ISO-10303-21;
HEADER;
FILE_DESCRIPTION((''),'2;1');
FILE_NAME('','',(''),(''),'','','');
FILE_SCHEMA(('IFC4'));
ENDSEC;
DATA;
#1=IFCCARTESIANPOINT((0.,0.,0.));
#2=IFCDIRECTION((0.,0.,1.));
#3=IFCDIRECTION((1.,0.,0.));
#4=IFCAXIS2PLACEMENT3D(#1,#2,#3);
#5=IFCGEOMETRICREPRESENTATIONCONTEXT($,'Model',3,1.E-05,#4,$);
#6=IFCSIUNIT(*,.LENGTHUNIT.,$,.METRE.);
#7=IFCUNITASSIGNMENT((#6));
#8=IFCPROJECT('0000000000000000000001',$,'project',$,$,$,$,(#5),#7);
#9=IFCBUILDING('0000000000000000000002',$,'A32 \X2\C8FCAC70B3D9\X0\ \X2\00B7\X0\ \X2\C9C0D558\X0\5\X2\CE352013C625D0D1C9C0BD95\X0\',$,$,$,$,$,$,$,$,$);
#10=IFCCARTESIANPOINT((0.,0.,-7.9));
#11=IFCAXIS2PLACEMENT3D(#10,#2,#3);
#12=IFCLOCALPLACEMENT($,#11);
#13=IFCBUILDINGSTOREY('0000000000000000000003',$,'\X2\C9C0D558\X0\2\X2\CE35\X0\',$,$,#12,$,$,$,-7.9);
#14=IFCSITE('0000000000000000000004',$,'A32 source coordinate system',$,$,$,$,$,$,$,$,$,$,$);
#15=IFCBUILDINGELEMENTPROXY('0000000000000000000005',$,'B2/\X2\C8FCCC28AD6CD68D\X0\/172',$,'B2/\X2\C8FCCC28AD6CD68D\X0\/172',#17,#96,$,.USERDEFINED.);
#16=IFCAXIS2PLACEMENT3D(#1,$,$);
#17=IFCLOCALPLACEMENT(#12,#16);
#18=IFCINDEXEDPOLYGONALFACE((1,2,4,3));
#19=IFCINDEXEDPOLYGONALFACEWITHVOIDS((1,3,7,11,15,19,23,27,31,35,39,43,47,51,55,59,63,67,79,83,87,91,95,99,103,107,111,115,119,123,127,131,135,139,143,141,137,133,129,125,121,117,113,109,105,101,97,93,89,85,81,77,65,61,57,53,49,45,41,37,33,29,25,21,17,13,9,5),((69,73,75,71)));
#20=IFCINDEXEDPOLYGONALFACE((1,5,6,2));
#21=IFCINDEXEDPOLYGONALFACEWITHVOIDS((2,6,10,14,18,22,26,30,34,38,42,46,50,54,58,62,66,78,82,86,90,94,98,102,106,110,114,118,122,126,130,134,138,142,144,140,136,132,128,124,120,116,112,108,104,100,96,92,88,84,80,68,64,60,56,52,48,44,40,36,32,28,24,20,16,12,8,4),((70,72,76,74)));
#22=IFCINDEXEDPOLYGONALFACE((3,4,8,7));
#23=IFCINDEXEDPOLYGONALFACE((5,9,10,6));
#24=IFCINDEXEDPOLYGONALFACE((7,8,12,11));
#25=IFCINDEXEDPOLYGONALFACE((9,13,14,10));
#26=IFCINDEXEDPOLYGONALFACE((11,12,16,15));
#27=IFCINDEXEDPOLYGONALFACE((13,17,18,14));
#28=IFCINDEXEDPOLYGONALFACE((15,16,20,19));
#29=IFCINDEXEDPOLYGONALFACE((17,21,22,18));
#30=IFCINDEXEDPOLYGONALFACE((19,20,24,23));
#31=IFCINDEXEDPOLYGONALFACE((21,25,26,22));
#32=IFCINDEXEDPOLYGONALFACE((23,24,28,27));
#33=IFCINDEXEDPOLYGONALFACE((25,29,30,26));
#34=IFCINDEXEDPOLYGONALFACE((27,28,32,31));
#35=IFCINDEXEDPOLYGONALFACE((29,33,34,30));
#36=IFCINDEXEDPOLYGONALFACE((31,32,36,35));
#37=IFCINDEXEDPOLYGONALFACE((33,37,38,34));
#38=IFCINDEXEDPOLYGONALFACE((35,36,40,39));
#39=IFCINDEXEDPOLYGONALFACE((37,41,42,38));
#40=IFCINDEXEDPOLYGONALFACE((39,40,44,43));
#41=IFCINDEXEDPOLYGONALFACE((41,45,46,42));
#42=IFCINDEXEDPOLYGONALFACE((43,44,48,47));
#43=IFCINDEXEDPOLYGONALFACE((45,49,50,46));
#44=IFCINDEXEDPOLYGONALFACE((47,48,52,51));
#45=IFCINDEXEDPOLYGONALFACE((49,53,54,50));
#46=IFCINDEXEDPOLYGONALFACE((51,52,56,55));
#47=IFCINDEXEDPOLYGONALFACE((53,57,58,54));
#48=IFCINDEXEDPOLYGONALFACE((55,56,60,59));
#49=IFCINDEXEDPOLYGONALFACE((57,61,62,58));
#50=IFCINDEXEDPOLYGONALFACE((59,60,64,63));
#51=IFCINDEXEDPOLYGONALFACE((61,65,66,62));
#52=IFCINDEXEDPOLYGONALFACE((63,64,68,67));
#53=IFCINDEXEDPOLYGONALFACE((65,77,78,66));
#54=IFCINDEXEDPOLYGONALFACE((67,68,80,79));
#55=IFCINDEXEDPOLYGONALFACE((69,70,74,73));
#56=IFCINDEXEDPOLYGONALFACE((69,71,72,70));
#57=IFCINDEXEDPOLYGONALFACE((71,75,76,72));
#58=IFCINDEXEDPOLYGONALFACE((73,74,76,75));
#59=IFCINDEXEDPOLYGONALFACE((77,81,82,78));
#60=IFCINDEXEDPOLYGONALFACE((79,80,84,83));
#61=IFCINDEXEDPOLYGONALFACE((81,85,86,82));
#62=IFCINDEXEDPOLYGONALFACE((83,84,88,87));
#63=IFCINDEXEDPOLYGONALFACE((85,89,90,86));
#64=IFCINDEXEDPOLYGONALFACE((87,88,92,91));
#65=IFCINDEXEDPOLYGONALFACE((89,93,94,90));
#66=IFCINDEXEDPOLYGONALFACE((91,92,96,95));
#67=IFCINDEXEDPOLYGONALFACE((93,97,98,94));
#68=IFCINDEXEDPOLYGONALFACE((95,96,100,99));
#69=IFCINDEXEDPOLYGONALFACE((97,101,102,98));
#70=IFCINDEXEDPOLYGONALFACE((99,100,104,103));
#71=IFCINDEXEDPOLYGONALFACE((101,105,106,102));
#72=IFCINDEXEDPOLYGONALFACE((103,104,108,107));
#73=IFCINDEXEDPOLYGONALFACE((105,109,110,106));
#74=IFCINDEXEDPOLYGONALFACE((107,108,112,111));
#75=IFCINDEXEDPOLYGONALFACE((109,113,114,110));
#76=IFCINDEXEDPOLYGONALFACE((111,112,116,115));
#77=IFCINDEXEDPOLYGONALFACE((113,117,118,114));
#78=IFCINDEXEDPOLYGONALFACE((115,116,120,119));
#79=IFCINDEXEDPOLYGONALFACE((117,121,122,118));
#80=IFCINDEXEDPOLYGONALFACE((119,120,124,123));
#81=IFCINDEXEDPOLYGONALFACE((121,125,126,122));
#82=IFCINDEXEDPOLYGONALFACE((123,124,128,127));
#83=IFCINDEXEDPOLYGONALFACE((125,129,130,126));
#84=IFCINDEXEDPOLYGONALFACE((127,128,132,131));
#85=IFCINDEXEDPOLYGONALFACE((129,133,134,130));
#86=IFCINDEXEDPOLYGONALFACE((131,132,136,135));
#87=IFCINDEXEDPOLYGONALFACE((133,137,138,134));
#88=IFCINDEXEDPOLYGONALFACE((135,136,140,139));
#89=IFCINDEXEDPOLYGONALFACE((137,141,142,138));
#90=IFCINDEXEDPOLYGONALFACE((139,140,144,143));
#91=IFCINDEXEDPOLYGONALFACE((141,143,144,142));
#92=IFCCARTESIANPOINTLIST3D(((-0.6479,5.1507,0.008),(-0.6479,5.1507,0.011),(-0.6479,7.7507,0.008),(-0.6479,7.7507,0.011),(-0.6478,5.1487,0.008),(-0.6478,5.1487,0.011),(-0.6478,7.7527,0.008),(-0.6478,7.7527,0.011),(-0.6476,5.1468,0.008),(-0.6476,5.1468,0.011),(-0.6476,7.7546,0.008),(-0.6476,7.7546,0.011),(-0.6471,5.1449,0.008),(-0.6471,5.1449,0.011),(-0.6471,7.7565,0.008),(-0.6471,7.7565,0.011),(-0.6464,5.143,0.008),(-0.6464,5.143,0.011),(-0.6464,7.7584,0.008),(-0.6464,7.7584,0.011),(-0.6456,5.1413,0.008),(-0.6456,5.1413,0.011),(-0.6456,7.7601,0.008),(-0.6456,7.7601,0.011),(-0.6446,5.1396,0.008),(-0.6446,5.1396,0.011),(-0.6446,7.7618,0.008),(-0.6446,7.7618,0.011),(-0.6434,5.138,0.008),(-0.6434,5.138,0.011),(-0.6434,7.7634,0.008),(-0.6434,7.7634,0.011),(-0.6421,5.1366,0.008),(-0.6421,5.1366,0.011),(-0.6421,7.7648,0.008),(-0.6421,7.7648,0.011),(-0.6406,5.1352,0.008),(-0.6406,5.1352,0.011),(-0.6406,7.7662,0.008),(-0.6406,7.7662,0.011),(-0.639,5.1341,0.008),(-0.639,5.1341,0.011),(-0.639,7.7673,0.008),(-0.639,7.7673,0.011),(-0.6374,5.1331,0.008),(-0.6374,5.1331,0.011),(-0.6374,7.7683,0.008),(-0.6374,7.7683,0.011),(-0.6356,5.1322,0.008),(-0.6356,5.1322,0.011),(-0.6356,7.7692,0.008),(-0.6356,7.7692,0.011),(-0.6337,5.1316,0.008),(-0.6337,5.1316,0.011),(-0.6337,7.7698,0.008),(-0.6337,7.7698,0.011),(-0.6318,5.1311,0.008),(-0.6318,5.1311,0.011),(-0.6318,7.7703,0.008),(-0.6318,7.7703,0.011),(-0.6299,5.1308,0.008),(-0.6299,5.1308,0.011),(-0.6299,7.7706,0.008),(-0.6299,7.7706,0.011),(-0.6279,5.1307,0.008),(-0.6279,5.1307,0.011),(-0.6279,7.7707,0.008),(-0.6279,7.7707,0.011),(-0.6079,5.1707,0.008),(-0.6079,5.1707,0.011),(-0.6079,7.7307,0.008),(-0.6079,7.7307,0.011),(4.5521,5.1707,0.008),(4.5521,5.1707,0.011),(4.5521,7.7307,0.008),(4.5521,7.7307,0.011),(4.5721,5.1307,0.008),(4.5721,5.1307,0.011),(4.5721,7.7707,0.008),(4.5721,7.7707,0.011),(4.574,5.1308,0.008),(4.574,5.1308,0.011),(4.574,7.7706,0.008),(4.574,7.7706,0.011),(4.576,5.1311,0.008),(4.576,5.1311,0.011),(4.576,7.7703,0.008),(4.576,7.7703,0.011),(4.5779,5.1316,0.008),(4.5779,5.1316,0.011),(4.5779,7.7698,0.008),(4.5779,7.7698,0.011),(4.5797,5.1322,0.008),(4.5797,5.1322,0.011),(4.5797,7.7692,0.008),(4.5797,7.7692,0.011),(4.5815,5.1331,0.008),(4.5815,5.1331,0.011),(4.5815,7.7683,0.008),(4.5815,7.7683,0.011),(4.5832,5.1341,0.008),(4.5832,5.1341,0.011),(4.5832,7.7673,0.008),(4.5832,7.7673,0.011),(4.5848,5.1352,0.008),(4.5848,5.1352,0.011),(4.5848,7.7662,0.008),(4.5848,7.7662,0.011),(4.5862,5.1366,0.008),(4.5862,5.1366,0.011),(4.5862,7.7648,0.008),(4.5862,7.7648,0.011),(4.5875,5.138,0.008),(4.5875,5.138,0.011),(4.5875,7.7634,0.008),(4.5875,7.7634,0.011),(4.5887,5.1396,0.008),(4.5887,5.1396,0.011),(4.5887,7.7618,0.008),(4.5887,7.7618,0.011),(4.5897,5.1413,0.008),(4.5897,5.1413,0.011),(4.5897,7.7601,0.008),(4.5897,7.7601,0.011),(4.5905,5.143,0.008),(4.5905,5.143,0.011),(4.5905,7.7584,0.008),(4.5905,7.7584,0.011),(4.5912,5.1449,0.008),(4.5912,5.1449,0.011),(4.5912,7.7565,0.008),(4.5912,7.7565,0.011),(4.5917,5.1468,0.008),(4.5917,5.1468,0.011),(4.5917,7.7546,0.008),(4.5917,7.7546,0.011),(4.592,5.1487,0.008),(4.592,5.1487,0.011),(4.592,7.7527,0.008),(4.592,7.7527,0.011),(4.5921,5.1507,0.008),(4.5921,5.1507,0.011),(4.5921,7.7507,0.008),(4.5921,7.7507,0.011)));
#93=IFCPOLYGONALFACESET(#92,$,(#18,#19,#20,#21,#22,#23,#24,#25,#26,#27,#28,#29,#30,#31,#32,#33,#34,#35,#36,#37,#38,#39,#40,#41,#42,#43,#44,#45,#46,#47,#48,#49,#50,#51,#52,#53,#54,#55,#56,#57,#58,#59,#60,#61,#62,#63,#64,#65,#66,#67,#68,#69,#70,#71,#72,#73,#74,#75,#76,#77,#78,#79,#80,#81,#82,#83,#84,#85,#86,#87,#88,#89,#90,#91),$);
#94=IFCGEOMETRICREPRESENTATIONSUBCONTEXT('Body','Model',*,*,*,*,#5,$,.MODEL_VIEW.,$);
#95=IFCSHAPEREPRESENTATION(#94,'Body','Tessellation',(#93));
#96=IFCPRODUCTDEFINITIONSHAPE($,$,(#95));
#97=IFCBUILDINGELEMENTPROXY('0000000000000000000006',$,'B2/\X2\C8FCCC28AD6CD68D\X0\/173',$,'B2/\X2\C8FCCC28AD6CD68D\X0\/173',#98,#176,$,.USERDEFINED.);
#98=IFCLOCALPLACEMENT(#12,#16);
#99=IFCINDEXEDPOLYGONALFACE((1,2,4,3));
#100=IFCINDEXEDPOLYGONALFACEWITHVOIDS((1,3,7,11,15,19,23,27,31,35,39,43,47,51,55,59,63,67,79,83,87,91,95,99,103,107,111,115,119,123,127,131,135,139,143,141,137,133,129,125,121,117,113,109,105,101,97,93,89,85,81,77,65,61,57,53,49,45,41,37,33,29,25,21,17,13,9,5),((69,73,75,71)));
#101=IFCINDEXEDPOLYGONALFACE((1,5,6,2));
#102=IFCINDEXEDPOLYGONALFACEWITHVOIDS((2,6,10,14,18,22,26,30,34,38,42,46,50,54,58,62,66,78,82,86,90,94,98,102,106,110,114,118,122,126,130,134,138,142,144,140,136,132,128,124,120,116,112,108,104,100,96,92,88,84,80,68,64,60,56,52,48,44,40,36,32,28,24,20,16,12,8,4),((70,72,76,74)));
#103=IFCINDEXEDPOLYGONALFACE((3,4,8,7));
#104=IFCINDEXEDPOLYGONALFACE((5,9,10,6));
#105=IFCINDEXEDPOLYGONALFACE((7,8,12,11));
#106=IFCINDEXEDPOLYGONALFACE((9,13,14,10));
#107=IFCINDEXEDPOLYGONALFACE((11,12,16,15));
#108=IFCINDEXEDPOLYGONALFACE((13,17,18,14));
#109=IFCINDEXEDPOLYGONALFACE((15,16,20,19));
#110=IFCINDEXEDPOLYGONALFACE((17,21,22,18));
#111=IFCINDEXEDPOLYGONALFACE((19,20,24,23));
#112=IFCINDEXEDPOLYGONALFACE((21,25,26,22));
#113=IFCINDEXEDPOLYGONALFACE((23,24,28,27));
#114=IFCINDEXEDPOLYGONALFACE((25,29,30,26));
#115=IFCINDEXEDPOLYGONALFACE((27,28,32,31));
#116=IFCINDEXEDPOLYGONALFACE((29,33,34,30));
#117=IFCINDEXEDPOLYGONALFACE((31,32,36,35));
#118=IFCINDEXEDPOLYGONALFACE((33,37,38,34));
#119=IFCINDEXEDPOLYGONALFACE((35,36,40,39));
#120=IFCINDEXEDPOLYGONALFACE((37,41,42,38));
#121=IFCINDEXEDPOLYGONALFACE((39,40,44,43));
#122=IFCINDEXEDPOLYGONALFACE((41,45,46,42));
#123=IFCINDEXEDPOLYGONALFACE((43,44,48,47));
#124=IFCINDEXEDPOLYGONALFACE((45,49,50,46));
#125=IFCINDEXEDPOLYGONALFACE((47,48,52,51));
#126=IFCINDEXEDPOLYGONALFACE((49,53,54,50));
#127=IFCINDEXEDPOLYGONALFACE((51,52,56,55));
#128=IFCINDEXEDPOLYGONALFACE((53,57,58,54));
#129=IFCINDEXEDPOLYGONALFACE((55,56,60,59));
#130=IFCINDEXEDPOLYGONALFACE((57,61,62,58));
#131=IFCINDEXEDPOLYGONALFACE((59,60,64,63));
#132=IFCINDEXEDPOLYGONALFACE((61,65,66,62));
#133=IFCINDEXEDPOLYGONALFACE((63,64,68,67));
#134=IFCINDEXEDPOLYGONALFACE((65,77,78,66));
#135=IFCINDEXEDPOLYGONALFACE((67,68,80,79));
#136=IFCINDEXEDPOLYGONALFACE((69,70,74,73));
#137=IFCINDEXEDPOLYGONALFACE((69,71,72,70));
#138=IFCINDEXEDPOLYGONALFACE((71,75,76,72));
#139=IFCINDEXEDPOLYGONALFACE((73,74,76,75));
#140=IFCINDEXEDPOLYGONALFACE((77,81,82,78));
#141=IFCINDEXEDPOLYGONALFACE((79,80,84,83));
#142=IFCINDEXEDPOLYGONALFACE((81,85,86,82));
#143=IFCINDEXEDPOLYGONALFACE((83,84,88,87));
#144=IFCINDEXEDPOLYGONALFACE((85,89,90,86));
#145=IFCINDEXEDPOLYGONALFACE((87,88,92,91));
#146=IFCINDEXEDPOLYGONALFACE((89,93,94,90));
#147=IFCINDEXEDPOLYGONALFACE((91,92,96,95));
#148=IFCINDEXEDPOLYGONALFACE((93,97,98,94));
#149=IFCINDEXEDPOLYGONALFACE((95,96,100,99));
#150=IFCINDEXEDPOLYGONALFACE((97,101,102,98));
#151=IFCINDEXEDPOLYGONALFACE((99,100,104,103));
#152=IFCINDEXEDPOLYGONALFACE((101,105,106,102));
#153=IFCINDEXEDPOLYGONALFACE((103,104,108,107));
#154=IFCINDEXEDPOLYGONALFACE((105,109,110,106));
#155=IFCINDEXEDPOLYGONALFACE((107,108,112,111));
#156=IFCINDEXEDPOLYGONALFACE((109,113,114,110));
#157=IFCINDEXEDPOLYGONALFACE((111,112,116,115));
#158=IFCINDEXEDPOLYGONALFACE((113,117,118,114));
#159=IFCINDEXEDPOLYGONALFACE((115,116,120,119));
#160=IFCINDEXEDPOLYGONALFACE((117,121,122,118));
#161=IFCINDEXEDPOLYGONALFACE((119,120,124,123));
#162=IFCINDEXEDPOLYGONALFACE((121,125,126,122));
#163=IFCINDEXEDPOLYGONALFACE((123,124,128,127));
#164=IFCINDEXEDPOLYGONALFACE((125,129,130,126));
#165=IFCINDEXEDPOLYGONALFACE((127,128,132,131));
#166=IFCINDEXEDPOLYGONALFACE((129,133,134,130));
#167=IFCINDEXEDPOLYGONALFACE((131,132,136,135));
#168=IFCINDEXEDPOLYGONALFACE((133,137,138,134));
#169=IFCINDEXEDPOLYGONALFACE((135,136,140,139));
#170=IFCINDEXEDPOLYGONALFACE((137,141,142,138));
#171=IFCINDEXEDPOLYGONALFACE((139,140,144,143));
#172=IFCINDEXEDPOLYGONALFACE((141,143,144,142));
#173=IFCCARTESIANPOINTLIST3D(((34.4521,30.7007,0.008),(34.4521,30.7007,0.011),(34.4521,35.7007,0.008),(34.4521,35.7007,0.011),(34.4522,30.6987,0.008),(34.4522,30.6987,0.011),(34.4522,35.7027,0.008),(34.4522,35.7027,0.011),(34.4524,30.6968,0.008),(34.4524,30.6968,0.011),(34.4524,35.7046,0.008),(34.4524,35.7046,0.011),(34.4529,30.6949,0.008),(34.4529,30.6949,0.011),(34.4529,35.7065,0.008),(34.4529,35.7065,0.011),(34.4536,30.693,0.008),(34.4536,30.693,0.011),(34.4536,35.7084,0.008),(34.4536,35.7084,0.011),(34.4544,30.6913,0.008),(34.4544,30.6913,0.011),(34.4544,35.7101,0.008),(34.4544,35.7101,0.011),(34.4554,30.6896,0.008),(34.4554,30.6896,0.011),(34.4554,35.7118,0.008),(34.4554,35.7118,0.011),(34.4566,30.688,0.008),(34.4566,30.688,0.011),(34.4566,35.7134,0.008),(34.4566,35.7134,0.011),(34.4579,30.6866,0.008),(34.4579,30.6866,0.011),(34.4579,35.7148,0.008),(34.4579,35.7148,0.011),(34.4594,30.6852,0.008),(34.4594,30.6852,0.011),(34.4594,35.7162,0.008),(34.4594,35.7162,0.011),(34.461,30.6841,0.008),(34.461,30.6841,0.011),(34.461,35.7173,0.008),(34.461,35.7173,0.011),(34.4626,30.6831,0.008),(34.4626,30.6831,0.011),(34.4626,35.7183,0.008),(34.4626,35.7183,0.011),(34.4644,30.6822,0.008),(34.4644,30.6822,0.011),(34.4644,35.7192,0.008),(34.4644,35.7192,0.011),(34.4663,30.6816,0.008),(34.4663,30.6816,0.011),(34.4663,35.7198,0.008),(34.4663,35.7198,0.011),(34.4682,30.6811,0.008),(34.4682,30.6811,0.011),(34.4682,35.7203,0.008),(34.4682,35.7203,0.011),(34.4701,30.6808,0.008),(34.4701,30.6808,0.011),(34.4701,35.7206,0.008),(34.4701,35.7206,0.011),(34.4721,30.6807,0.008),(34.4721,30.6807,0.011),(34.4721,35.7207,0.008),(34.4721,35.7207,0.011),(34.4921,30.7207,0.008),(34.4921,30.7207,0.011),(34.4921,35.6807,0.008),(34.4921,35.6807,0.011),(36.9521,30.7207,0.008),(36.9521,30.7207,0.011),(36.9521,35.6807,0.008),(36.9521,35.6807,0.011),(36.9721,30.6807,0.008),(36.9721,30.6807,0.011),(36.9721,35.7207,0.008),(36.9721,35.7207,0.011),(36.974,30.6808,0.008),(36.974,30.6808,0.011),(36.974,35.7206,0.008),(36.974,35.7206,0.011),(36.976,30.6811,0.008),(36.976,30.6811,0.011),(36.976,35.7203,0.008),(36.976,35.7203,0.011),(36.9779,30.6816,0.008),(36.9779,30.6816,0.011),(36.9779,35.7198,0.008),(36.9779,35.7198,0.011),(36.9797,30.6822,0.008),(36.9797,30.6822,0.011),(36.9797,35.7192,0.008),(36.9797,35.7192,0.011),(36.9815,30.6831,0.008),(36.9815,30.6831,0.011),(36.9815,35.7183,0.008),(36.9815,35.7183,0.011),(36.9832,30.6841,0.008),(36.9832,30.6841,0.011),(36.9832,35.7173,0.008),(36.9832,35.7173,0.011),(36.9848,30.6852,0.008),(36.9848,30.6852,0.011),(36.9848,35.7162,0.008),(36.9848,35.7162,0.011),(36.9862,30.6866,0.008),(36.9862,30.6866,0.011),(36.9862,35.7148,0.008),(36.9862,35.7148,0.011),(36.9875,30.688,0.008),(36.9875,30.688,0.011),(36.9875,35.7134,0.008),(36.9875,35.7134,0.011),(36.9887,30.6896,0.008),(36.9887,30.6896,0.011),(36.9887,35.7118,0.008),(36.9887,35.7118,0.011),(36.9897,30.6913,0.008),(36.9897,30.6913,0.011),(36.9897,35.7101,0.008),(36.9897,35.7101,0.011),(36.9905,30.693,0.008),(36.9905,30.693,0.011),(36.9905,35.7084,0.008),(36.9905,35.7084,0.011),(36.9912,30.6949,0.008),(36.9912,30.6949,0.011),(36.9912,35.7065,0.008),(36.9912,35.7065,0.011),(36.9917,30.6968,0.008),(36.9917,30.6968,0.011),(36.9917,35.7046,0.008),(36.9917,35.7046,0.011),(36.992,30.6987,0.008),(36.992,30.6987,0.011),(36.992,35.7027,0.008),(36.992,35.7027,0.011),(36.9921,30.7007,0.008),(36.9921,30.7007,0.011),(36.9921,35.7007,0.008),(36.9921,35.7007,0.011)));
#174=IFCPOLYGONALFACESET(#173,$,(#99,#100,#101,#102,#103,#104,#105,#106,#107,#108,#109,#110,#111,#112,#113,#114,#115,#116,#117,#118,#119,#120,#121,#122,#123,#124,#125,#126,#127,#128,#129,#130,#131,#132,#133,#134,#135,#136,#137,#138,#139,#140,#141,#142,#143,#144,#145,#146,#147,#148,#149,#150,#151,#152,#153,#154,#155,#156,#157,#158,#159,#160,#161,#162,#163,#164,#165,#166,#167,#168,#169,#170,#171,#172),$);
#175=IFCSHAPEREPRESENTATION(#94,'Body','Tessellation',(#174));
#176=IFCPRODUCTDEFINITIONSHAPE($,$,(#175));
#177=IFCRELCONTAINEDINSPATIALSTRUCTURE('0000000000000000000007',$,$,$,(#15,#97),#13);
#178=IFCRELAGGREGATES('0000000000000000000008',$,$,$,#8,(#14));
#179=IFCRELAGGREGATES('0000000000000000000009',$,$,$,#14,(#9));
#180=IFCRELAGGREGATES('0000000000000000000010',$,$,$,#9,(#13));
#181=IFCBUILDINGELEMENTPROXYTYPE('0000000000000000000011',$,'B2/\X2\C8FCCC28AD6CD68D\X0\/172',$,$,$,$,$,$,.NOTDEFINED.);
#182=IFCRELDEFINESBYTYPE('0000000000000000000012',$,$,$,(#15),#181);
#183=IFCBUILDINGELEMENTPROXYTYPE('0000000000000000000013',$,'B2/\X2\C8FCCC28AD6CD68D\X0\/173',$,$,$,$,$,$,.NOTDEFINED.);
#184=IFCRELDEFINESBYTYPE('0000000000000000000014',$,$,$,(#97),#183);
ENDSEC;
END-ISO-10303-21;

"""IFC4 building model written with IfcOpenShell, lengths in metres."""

from ifc_helpers import new_model, si_unit, frame, origin, origin_with_axes, place, context, subcontext, project, spatial, polyline, outline, extrude, source, transform, mapped, type_object, type_shapes, element, save


model = new_model("IFC4")

# Units and contexts
model_context = context("Model", 3, precision=1e-05, world=origin_with_axes())
body_context = subcontext(model_context, "Body", "Model", "MODEL_VIEW")
ifc_project = project(units=[si_unit("LENGTHUNIT", "METRE")], contexts=[model_context])

# Site, building, storey
site = spatial("IfcSite", under=ifc_project, Name="A32 source coordinate system")
building = spatial("IfcBuilding", under=site, Name="A32 주거동 · 지하5층–옥탑지붕")
storey_placement = place(None, frame((0.0, 0.0, -7.9), z_axis=(0.0, 0.0, 1.0), x_axis=(1.0, 0.0, 0.0)))
storey = spatial("IfcBuildingStorey", under=building, at=storey_placement, Name="지하2층", Elevation=-7.9)

# Building element proxies
building_element_proxy_type_1 = type_object("IfcBuildingElementProxyType", Name="B2/주차구획/172", PredefinedType="NOTDEFINED")
shared_shape_1 = source(origin(), body_context, "Body", "SweptSolid", [
    extrude(outline(polyline([(4.5921, 5.1507), (4.592, 5.1487), (4.5917, 5.1468), (4.5912, 5.1449), (4.5905, 5.143), (4.5897, 5.1413), (4.5887, 5.1396), (4.5875, 5.138), (4.5862, 5.1366), (4.5848, 5.1352), (4.5832, 5.1341), (4.5815, 5.1331), (4.5797, 5.1322), (4.5779, 5.1316), (4.576, 5.1311), (4.574, 5.1308), (4.5721, 5.1307), (-0.6279, 5.1307), (-0.6299, 5.1308), (-0.6318, 5.1311), (-0.6337, 5.1316), (-0.6356, 5.1322), (-0.6374, 5.1331), (-0.639, 5.1341), (-0.6406, 5.1352), (-0.6421, 5.1366), (-0.6434, 5.138), (-0.6446, 5.1396), (-0.6456, 5.1413), (-0.6464, 5.143), (-0.6471, 5.1449), (-0.6476, 5.1468), (-0.6478, 5.1487), (-0.6479, 5.1507), (-0.6479, 7.7507), (-0.6478, 7.7527), (-0.6476, 7.7546), (-0.6471, 7.7565), (-0.6464, 7.7584), (-0.6456, 7.7601), (-0.6446, 7.7618), (-0.6434, 7.7634), (-0.6421, 7.7648), (-0.6406, 7.7662), (-0.639, 7.7673), (-0.6374, 7.7683), (-0.6356, 7.7692), (-0.6337, 7.7698), (-0.6318, 7.7703), (-0.6299, 7.7706), (-0.6279, 7.7707), (4.5721, 7.7707), (4.574, 7.7706), (4.576, 7.7703), (4.5779, 7.7698), (4.5797, 7.7692), (4.5815, 7.7683), (4.5832, 7.7673), (4.5848, 7.7662), (4.5862, 7.7648), (4.5875, 7.7634), (4.5887, 7.7618), (4.5897, 7.7601), (4.5905, 7.7584), (4.5912, 7.7565), (4.5917, 7.7546), (4.592, 7.7527), (4.5921, 7.7507), (4.5921, 5.1507)]), holes=[polyline([(4.5521, 5.1707), (4.5521, 7.7307), (-0.6079, 7.7307), (-0.6079, 5.1707), (4.5521, 5.1707)])]), frame((0.0, 0.0, 0.008)), (0.0, 0.0, 1.0), 0.003),
])
type_shapes(building_element_proxy_type_1, [shared_shape_1])
proxy_1_placement = place(storey_placement, origin_with_axes())
element("IfcBuildingElementProxy", 1, at=proxy_1_placement, inside=storey, type_object=building_element_proxy_type_1, Name="B2/주차구획/172", ObjectType="B2/주차구획/172", PredefinedType="USERDEFINED", context=body_context, shape_type="MappedRepresentation", body=[
    mapped(shared_shape_1, transform((0.0, 0.0, 0.0), scale=1.0)),
])
building_element_proxy_type_2 = type_object("IfcBuildingElementProxyType", Name="B2/주차구획/173", PredefinedType="NOTDEFINED")
shared_shape_2 = source(origin(), body_context, "Body", "SweptSolid", [
    extrude(outline(polyline([(34.4521, 35.7007), (34.4522, 35.7027), (34.4524, 35.7046), (34.4529, 35.7065), (34.4536, 35.7084), (34.4544, 35.7101), (34.4554, 35.7118), (34.4566, 35.7134), (34.4579, 35.7148), (34.4594, 35.7162), (34.461, 35.7173), (34.4626, 35.7183), (34.4644, 35.7192), (34.4663, 35.7198), (34.4682, 35.7203), (34.4701, 35.7206), (34.4721, 35.7207), (36.9721, 35.7207), (36.974, 35.7206), (36.976, 35.7203), (36.9779, 35.7198), (36.9797, 35.7192), (36.9815, 35.7183), (36.9832, 35.7173), (36.9848, 35.7162), (36.9862, 35.7148), (36.9875, 35.7134), (36.9887, 35.7118), (36.9897, 35.7101), (36.9905, 35.7084), (36.9912, 35.7065), (36.9917, 35.7046), (36.992, 35.7027), (36.9921, 35.7007), (36.9921, 30.7007), (36.992, 30.6987), (36.9917, 30.6968), (36.9912, 30.6949), (36.9905, 30.693), (36.9897, 30.6913), (36.9887, 30.6896), (36.9875, 30.688), (36.9862, 30.6866), (36.9848, 30.6852), (36.9832, 30.6841), (36.9815, 30.6831), (36.9797, 30.6822), (36.9779, 30.6816), (36.976, 30.6811), (36.974, 30.6808), (36.9721, 30.6807), (34.4721, 30.6807), (34.4701, 30.6808), (34.4682, 30.6811), (34.4663, 30.6816), (34.4644, 30.6822), (34.4626, 30.6831), (34.461, 30.6841), (34.4594, 30.6852), (34.4579, 30.6866), (34.4566, 30.688), (34.4554, 30.6896), (34.4544, 30.6913), (34.4536, 30.693), (34.4529, 30.6949), (34.4524, 30.6968), (34.4522, 30.6987), (34.4521, 30.7007), (34.4521, 35.7007)]), holes=[polyline([(34.4921, 35.6807), (34.4921, 30.7207), (36.9521, 30.7207), (36.9521, 35.6807), (34.4921, 35.6807)])]), frame((0.0, 0.0, 0.008)), (0.0, 0.0, 1.0), 0.003),
])
type_shapes(building_element_proxy_type_2, [shared_shape_2])
proxy_2_placement = place(storey_placement, origin_with_axes())
element("IfcBuildingElementProxy", 2, at=proxy_2_placement, inside=storey, type_object=building_element_proxy_type_2, Name="B2/주차구획/173", ObjectType="B2/주차구획/173", PredefinedType="USERDEFINED", context=body_context, shape_type="MappedRepresentation", body=[
    mapped(shared_shape_2, transform((0.0, 0.0, 0.0), scale=1.0)),
])

save(model, "model.ifc")
